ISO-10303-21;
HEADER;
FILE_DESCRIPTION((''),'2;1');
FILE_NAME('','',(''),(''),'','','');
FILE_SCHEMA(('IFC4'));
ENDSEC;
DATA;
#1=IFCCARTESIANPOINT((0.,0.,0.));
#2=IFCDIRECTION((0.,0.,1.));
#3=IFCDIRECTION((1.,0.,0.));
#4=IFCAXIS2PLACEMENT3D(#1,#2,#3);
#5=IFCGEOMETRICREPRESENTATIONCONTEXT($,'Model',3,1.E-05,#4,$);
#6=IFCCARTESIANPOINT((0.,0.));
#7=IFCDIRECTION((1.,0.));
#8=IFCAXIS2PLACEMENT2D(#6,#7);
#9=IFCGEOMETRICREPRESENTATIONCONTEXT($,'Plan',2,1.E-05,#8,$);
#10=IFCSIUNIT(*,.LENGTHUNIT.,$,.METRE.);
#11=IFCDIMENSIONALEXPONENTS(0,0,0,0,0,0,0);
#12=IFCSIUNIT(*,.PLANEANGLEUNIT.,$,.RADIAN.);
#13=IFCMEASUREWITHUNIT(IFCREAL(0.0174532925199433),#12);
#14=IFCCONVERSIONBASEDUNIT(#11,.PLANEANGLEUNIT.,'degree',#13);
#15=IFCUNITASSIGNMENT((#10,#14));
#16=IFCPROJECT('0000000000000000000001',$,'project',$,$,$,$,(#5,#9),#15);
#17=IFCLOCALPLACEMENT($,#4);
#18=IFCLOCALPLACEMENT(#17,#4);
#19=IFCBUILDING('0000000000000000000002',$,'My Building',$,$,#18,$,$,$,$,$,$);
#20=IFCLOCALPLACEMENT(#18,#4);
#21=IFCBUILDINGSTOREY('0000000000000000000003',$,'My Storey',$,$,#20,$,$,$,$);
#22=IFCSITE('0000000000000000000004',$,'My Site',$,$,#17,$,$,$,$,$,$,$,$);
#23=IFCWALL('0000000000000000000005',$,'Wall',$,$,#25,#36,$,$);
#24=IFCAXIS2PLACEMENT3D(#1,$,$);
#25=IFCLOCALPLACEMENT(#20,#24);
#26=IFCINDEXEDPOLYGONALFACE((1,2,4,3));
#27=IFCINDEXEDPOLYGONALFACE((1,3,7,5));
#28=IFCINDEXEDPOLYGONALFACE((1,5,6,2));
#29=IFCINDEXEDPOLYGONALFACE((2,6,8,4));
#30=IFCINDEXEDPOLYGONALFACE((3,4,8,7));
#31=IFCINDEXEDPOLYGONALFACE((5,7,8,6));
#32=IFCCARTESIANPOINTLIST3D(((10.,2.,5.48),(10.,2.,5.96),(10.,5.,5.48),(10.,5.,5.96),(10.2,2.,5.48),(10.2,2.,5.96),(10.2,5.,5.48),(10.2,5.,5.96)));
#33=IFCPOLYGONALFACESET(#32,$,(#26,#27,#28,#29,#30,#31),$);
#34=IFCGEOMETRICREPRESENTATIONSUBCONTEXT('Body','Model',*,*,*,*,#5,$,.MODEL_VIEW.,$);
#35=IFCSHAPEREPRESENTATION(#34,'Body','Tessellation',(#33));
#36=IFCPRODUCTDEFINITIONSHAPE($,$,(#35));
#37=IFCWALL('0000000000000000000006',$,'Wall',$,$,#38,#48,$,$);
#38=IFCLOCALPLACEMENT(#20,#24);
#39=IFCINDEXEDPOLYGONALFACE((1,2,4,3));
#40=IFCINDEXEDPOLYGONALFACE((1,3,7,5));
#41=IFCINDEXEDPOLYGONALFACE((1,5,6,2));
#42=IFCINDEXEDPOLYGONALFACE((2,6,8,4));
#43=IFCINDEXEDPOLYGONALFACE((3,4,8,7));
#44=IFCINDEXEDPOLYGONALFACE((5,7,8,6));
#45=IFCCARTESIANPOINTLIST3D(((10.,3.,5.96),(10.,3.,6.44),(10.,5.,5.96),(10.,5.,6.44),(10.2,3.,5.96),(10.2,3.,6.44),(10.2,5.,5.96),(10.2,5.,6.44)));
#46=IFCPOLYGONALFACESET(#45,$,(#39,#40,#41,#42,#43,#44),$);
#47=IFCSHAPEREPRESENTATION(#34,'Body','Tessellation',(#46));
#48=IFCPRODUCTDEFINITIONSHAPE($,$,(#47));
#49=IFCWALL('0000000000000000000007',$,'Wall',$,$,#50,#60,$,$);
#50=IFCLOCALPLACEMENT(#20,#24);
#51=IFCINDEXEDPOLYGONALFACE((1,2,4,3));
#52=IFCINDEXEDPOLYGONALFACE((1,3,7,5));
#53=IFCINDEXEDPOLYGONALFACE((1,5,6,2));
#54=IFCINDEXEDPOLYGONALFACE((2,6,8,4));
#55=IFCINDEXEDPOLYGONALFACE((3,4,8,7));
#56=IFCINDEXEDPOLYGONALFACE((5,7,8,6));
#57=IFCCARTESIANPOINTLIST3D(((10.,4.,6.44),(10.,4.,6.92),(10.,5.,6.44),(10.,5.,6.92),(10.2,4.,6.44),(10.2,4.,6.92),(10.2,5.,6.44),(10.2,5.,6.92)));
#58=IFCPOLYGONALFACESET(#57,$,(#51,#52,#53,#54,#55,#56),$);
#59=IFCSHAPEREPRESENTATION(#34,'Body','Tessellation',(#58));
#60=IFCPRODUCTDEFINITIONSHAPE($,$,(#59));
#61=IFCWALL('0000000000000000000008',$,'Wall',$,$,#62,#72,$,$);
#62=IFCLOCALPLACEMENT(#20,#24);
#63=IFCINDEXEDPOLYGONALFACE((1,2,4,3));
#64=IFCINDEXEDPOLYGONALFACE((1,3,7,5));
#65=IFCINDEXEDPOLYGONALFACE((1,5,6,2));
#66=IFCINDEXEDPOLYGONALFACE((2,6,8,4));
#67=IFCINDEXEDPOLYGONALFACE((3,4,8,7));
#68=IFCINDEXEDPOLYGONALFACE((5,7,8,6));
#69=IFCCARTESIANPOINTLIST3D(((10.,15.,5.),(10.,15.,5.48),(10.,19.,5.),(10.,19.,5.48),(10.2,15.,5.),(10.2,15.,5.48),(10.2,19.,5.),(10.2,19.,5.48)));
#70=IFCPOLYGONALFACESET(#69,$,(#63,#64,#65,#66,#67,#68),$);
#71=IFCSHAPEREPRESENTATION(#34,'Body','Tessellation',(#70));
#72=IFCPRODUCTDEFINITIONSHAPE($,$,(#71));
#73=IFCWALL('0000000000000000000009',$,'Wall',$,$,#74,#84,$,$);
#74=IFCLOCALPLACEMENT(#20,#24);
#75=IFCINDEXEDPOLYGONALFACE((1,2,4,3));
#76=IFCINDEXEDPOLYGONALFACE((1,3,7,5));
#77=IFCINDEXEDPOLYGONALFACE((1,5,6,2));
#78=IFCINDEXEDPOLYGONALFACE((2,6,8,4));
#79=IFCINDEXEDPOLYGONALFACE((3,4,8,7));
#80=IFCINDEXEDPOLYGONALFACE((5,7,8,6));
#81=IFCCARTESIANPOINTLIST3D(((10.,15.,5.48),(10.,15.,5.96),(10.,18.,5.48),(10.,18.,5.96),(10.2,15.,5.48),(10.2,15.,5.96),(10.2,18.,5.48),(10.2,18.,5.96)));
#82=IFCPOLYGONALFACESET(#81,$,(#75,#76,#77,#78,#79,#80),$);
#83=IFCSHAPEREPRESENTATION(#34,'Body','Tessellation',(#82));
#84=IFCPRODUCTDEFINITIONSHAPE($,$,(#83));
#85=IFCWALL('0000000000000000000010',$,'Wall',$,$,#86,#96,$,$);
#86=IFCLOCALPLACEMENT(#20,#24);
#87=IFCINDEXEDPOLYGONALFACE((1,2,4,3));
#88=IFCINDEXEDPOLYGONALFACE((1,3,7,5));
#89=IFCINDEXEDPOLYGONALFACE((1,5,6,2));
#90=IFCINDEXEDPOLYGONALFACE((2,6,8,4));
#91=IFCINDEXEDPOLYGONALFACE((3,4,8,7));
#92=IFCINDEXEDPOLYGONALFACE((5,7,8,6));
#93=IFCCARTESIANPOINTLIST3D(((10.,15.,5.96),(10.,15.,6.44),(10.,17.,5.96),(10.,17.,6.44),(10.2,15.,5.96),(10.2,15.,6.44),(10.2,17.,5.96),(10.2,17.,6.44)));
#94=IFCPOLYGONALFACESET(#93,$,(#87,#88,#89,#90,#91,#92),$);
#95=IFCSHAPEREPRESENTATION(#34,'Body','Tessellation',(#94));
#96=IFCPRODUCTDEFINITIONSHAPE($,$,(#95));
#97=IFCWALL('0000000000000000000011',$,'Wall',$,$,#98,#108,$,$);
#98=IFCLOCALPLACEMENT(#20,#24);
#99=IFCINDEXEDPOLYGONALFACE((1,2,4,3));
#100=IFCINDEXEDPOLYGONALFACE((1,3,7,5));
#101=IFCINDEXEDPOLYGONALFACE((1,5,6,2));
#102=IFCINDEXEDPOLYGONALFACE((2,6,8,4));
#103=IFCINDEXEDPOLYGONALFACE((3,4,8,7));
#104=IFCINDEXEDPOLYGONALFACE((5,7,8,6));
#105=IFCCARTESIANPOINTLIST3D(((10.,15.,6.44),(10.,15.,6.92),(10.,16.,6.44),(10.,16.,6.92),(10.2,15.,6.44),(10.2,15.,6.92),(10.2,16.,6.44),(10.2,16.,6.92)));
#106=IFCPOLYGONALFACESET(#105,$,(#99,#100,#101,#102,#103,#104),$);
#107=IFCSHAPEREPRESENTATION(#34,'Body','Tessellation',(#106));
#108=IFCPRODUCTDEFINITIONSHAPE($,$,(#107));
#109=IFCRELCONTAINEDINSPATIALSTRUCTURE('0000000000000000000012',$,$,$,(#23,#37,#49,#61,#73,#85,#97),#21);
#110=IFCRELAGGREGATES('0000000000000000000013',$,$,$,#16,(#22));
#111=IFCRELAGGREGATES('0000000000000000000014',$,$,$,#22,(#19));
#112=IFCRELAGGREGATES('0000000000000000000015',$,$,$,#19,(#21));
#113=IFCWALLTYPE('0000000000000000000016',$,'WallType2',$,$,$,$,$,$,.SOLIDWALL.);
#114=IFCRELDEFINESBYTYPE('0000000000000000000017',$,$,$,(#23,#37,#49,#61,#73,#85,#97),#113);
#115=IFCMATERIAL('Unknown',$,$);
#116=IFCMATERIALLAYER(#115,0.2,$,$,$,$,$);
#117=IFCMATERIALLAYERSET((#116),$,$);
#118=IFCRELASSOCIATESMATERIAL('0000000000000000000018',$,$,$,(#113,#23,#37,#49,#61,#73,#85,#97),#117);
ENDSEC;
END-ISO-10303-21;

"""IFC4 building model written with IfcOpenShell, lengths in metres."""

from ifc_helpers import new_model, entity, si_unit, converted_unit, frame, origin_with_axes, origin_2d_with_axis, place, context, subcontext, project, spatial, indexed_curve, outline, extrude, material, layer, layer_set, layer_usage, type_object, element, save


model = new_model("IFC4")

# Units and contexts
model_context = context("Model", 3, precision=1e-05, world=origin_with_axes())
plan_context = context("Plan", 2, precision=1e-05, world=origin_2d_with_axis())
body_context_1 = subcontext(model_context, "Body", "Model", "MODEL_VIEW")
ifc_project = project(units=[si_unit("LENGTHUNIT", "METRE"), converted_unit("PLANEANGLEUNIT", "degree", entity("IfcReal", 0.0174532925199433), si_unit("PLANEANGLEUNIT", "RADIAN"), dimensions=[0, 0, 0, 0, 0, 0, 0])], contexts=[model_context, plan_context])

# Site, building, storey
site_placement = place(None, origin_with_axes())
site = spatial("IfcSite", under=ifc_project, at=site_placement, Name="My Site")
building_placement = place(site_placement, origin_with_axes())
building = spatial("IfcBuilding", under=site, at=building_placement, Name="My Building")
storey_placement = place(building_placement, origin_with_axes())
storey = spatial("IfcBuildingStorey", under=building, at=storey_placement, Name="My Storey")

# Walls
ifc_material = material(Name="Unknown")
ifc_layer_1 = layer(ifc_material, 0.2)
ifc_layer_set_1 = layer_set([ifc_layer_1])
ifc_layer_usage_1 = layer_usage(ifc_layer_set_1, "AXIS2", "POSITIVE", 0.0)
wall_type_1 = type_object("IfcWallType", Name="WallType2", PredefinedType="SOLIDWALL", material=ifc_layer_set_1)
wall_1_placement = place(storey_placement, frame((10.2, 2.0, 5.48), z_axis=(0.0, 0.0, 1.0), x_axis=(0.0, 1.0, 0.0)))
element("IfcWall", 1, at=wall_1_placement, inside=storey, type_object=wall_type_1, material=ifc_layer_usage_1, Name="Wall", context=body_context_1, shape_type="SweptSolid", body=[
    extrude(outline(indexed_curve([(0.0, 0.0), (0.0, 0.2), (3.0, 0.2), (3.0, 0.0), (0.0, 0.0)], self_intersect=False)), origin_with_axes(), (0.0, 0.0, 1.0), 0.48),
])
ifc_layer_usage_2 = layer_usage(ifc_layer_set_1, "AXIS2", "POSITIVE", 0.0)
wall_2_placement = place(storey_placement, frame((10.2, 3.0, 5.96), z_axis=(0.0, 0.0, 1.0), x_axis=(0.0, 1.0, 0.0)))
element("IfcWall", 2, at=wall_2_placement, inside=storey, type_object=wall_type_1, material=ifc_layer_usage_2, Name="Wall", context=body_context_1, shape_type="SweptSolid", body=[
    extrude(outline(indexed_curve([(0.0, 0.0), (0.0, 0.2), (2.0, 0.2), (2.0, 0.0), (0.0, 0.0)], self_intersect=False)), origin_with_axes(), (0.0, 0.0, 1.0), 0.48),
])
ifc_layer_usage_3 = layer_usage(ifc_layer_set_1, "AXIS2", "POSITIVE", 0.0)
wall_3_placement = place(storey_placement, frame((10.2, 4.0, 6.44), z_axis=(0.0, 0.0, 1.0), x_axis=(0.0, 1.0, 0.0)))
element("IfcWall", 3, at=wall_3_placement, inside=storey, type_object=wall_type_1, material=ifc_layer_usage_3, Name="Wall", context=body_context_1, shape_type="SweptSolid", body=[
    extrude(outline(indexed_curve([(0.0, 0.0), (0.0, 0.2), (1.0, 0.2), (1.0, 0.0), (0.0, 0.0)], self_intersect=False)), origin_with_axes(), (0.0, 0.0, 1.0), 0.48),
])
ifc_layer_usage_4 = layer_usage(ifc_layer_set_1, "AXIS2", "POSITIVE", 0.0)
wall_4_placement = place(storey_placement, frame((10.2, 15.0, 5.0), z_axis=(0.0, 0.0, 1.0), x_axis=(0.0, 1.0, 0.0)))
element("IfcWall", 4, at=wall_4_placement, inside=storey, type_object=wall_type_1, material=ifc_layer_usage_4, Name="Wall", context=body_context_1, shape_type="SweptSolid", body=[
    extrude(outline(indexed_curve([(0.0, 0.0), (0.0, 0.2), (4.0, 0.2), (4.0, 0.0), (0.0, 0.0)], self_intersect=False)), origin_with_axes(), (0.0, 0.0, 1.0), 0.48),
])
ifc_layer_usage_5 = layer_usage(ifc_layer_set_1, "AXIS2", "POSITIVE", 0.0)
wall_5_placement = place(storey_placement, frame((10.2, 15.0, 5.48), z_axis=(0.0, 0.0, 1.0), x_axis=(0.0, 1.0, 0.0)))
element("IfcWall", 5, at=wall_5_placement, inside=storey, type_object=wall_type_1, material=ifc_layer_usage_5, Name="Wall", context=body_context_1, shape_type="SweptSolid", body=[
    extrude(outline(indexed_curve([(0.0, 0.0), (0.0, 0.2), (3.0, 0.2), (3.0, 0.0), (0.0, 0.0)], self_intersect=False)), origin_with_axes(), (0.0, 0.0, 1.0), 0.48),
])
ifc_layer_usage_6 = layer_usage(ifc_layer_set_1, "AXIS2", "POSITIVE", 0.0)
wall_6_placement = place(storey_placement, frame((10.2, 15.0, 5.96), z_axis=(0.0, 0.0, 1.0), x_axis=(0.0, 1.0, 0.0)))
element("IfcWall", 6, at=wall_6_placement, inside=storey, type_object=wall_type_1, material=ifc_layer_usage_6, Name="Wall", context=body_context_1, shape_type="SweptSolid", body=[
    extrude(outline(indexed_curve([(0.0, 0.0), (0.0, 0.2), (2.0, 0.2), (2.0, 0.0), (0.0, 0.0)], self_intersect=False)), origin_with_axes(), (0.0, 0.0, 1.0), 0.48),
])
ifc_layer_usage_7 = layer_usage(ifc_layer_set_1, "AXIS2", "POSITIVE", 0.0)
wall_7_placement = place(storey_placement, frame((10.2, 15.0, 6.44), z_axis=(0.0, 0.0, 1.0), x_axis=(0.0, 1.0, 0.0)))
element("IfcWall", 7, at=wall_7_placement, inside=storey, type_object=wall_type_1, material=ifc_layer_usage_7, Name="Wall", context=body_context_1, shape_type="SweptSolid", body=[
    extrude(outline(indexed_curve([(0.0, 0.0), (0.0, 0.2), (1.0, 0.2), (1.0, 0.0), (0.0, 0.0)], self_intersect=False)), origin_with_axes(), (0.0, 0.0, 1.0), 0.48),
])

save(model, "model.ifc")
